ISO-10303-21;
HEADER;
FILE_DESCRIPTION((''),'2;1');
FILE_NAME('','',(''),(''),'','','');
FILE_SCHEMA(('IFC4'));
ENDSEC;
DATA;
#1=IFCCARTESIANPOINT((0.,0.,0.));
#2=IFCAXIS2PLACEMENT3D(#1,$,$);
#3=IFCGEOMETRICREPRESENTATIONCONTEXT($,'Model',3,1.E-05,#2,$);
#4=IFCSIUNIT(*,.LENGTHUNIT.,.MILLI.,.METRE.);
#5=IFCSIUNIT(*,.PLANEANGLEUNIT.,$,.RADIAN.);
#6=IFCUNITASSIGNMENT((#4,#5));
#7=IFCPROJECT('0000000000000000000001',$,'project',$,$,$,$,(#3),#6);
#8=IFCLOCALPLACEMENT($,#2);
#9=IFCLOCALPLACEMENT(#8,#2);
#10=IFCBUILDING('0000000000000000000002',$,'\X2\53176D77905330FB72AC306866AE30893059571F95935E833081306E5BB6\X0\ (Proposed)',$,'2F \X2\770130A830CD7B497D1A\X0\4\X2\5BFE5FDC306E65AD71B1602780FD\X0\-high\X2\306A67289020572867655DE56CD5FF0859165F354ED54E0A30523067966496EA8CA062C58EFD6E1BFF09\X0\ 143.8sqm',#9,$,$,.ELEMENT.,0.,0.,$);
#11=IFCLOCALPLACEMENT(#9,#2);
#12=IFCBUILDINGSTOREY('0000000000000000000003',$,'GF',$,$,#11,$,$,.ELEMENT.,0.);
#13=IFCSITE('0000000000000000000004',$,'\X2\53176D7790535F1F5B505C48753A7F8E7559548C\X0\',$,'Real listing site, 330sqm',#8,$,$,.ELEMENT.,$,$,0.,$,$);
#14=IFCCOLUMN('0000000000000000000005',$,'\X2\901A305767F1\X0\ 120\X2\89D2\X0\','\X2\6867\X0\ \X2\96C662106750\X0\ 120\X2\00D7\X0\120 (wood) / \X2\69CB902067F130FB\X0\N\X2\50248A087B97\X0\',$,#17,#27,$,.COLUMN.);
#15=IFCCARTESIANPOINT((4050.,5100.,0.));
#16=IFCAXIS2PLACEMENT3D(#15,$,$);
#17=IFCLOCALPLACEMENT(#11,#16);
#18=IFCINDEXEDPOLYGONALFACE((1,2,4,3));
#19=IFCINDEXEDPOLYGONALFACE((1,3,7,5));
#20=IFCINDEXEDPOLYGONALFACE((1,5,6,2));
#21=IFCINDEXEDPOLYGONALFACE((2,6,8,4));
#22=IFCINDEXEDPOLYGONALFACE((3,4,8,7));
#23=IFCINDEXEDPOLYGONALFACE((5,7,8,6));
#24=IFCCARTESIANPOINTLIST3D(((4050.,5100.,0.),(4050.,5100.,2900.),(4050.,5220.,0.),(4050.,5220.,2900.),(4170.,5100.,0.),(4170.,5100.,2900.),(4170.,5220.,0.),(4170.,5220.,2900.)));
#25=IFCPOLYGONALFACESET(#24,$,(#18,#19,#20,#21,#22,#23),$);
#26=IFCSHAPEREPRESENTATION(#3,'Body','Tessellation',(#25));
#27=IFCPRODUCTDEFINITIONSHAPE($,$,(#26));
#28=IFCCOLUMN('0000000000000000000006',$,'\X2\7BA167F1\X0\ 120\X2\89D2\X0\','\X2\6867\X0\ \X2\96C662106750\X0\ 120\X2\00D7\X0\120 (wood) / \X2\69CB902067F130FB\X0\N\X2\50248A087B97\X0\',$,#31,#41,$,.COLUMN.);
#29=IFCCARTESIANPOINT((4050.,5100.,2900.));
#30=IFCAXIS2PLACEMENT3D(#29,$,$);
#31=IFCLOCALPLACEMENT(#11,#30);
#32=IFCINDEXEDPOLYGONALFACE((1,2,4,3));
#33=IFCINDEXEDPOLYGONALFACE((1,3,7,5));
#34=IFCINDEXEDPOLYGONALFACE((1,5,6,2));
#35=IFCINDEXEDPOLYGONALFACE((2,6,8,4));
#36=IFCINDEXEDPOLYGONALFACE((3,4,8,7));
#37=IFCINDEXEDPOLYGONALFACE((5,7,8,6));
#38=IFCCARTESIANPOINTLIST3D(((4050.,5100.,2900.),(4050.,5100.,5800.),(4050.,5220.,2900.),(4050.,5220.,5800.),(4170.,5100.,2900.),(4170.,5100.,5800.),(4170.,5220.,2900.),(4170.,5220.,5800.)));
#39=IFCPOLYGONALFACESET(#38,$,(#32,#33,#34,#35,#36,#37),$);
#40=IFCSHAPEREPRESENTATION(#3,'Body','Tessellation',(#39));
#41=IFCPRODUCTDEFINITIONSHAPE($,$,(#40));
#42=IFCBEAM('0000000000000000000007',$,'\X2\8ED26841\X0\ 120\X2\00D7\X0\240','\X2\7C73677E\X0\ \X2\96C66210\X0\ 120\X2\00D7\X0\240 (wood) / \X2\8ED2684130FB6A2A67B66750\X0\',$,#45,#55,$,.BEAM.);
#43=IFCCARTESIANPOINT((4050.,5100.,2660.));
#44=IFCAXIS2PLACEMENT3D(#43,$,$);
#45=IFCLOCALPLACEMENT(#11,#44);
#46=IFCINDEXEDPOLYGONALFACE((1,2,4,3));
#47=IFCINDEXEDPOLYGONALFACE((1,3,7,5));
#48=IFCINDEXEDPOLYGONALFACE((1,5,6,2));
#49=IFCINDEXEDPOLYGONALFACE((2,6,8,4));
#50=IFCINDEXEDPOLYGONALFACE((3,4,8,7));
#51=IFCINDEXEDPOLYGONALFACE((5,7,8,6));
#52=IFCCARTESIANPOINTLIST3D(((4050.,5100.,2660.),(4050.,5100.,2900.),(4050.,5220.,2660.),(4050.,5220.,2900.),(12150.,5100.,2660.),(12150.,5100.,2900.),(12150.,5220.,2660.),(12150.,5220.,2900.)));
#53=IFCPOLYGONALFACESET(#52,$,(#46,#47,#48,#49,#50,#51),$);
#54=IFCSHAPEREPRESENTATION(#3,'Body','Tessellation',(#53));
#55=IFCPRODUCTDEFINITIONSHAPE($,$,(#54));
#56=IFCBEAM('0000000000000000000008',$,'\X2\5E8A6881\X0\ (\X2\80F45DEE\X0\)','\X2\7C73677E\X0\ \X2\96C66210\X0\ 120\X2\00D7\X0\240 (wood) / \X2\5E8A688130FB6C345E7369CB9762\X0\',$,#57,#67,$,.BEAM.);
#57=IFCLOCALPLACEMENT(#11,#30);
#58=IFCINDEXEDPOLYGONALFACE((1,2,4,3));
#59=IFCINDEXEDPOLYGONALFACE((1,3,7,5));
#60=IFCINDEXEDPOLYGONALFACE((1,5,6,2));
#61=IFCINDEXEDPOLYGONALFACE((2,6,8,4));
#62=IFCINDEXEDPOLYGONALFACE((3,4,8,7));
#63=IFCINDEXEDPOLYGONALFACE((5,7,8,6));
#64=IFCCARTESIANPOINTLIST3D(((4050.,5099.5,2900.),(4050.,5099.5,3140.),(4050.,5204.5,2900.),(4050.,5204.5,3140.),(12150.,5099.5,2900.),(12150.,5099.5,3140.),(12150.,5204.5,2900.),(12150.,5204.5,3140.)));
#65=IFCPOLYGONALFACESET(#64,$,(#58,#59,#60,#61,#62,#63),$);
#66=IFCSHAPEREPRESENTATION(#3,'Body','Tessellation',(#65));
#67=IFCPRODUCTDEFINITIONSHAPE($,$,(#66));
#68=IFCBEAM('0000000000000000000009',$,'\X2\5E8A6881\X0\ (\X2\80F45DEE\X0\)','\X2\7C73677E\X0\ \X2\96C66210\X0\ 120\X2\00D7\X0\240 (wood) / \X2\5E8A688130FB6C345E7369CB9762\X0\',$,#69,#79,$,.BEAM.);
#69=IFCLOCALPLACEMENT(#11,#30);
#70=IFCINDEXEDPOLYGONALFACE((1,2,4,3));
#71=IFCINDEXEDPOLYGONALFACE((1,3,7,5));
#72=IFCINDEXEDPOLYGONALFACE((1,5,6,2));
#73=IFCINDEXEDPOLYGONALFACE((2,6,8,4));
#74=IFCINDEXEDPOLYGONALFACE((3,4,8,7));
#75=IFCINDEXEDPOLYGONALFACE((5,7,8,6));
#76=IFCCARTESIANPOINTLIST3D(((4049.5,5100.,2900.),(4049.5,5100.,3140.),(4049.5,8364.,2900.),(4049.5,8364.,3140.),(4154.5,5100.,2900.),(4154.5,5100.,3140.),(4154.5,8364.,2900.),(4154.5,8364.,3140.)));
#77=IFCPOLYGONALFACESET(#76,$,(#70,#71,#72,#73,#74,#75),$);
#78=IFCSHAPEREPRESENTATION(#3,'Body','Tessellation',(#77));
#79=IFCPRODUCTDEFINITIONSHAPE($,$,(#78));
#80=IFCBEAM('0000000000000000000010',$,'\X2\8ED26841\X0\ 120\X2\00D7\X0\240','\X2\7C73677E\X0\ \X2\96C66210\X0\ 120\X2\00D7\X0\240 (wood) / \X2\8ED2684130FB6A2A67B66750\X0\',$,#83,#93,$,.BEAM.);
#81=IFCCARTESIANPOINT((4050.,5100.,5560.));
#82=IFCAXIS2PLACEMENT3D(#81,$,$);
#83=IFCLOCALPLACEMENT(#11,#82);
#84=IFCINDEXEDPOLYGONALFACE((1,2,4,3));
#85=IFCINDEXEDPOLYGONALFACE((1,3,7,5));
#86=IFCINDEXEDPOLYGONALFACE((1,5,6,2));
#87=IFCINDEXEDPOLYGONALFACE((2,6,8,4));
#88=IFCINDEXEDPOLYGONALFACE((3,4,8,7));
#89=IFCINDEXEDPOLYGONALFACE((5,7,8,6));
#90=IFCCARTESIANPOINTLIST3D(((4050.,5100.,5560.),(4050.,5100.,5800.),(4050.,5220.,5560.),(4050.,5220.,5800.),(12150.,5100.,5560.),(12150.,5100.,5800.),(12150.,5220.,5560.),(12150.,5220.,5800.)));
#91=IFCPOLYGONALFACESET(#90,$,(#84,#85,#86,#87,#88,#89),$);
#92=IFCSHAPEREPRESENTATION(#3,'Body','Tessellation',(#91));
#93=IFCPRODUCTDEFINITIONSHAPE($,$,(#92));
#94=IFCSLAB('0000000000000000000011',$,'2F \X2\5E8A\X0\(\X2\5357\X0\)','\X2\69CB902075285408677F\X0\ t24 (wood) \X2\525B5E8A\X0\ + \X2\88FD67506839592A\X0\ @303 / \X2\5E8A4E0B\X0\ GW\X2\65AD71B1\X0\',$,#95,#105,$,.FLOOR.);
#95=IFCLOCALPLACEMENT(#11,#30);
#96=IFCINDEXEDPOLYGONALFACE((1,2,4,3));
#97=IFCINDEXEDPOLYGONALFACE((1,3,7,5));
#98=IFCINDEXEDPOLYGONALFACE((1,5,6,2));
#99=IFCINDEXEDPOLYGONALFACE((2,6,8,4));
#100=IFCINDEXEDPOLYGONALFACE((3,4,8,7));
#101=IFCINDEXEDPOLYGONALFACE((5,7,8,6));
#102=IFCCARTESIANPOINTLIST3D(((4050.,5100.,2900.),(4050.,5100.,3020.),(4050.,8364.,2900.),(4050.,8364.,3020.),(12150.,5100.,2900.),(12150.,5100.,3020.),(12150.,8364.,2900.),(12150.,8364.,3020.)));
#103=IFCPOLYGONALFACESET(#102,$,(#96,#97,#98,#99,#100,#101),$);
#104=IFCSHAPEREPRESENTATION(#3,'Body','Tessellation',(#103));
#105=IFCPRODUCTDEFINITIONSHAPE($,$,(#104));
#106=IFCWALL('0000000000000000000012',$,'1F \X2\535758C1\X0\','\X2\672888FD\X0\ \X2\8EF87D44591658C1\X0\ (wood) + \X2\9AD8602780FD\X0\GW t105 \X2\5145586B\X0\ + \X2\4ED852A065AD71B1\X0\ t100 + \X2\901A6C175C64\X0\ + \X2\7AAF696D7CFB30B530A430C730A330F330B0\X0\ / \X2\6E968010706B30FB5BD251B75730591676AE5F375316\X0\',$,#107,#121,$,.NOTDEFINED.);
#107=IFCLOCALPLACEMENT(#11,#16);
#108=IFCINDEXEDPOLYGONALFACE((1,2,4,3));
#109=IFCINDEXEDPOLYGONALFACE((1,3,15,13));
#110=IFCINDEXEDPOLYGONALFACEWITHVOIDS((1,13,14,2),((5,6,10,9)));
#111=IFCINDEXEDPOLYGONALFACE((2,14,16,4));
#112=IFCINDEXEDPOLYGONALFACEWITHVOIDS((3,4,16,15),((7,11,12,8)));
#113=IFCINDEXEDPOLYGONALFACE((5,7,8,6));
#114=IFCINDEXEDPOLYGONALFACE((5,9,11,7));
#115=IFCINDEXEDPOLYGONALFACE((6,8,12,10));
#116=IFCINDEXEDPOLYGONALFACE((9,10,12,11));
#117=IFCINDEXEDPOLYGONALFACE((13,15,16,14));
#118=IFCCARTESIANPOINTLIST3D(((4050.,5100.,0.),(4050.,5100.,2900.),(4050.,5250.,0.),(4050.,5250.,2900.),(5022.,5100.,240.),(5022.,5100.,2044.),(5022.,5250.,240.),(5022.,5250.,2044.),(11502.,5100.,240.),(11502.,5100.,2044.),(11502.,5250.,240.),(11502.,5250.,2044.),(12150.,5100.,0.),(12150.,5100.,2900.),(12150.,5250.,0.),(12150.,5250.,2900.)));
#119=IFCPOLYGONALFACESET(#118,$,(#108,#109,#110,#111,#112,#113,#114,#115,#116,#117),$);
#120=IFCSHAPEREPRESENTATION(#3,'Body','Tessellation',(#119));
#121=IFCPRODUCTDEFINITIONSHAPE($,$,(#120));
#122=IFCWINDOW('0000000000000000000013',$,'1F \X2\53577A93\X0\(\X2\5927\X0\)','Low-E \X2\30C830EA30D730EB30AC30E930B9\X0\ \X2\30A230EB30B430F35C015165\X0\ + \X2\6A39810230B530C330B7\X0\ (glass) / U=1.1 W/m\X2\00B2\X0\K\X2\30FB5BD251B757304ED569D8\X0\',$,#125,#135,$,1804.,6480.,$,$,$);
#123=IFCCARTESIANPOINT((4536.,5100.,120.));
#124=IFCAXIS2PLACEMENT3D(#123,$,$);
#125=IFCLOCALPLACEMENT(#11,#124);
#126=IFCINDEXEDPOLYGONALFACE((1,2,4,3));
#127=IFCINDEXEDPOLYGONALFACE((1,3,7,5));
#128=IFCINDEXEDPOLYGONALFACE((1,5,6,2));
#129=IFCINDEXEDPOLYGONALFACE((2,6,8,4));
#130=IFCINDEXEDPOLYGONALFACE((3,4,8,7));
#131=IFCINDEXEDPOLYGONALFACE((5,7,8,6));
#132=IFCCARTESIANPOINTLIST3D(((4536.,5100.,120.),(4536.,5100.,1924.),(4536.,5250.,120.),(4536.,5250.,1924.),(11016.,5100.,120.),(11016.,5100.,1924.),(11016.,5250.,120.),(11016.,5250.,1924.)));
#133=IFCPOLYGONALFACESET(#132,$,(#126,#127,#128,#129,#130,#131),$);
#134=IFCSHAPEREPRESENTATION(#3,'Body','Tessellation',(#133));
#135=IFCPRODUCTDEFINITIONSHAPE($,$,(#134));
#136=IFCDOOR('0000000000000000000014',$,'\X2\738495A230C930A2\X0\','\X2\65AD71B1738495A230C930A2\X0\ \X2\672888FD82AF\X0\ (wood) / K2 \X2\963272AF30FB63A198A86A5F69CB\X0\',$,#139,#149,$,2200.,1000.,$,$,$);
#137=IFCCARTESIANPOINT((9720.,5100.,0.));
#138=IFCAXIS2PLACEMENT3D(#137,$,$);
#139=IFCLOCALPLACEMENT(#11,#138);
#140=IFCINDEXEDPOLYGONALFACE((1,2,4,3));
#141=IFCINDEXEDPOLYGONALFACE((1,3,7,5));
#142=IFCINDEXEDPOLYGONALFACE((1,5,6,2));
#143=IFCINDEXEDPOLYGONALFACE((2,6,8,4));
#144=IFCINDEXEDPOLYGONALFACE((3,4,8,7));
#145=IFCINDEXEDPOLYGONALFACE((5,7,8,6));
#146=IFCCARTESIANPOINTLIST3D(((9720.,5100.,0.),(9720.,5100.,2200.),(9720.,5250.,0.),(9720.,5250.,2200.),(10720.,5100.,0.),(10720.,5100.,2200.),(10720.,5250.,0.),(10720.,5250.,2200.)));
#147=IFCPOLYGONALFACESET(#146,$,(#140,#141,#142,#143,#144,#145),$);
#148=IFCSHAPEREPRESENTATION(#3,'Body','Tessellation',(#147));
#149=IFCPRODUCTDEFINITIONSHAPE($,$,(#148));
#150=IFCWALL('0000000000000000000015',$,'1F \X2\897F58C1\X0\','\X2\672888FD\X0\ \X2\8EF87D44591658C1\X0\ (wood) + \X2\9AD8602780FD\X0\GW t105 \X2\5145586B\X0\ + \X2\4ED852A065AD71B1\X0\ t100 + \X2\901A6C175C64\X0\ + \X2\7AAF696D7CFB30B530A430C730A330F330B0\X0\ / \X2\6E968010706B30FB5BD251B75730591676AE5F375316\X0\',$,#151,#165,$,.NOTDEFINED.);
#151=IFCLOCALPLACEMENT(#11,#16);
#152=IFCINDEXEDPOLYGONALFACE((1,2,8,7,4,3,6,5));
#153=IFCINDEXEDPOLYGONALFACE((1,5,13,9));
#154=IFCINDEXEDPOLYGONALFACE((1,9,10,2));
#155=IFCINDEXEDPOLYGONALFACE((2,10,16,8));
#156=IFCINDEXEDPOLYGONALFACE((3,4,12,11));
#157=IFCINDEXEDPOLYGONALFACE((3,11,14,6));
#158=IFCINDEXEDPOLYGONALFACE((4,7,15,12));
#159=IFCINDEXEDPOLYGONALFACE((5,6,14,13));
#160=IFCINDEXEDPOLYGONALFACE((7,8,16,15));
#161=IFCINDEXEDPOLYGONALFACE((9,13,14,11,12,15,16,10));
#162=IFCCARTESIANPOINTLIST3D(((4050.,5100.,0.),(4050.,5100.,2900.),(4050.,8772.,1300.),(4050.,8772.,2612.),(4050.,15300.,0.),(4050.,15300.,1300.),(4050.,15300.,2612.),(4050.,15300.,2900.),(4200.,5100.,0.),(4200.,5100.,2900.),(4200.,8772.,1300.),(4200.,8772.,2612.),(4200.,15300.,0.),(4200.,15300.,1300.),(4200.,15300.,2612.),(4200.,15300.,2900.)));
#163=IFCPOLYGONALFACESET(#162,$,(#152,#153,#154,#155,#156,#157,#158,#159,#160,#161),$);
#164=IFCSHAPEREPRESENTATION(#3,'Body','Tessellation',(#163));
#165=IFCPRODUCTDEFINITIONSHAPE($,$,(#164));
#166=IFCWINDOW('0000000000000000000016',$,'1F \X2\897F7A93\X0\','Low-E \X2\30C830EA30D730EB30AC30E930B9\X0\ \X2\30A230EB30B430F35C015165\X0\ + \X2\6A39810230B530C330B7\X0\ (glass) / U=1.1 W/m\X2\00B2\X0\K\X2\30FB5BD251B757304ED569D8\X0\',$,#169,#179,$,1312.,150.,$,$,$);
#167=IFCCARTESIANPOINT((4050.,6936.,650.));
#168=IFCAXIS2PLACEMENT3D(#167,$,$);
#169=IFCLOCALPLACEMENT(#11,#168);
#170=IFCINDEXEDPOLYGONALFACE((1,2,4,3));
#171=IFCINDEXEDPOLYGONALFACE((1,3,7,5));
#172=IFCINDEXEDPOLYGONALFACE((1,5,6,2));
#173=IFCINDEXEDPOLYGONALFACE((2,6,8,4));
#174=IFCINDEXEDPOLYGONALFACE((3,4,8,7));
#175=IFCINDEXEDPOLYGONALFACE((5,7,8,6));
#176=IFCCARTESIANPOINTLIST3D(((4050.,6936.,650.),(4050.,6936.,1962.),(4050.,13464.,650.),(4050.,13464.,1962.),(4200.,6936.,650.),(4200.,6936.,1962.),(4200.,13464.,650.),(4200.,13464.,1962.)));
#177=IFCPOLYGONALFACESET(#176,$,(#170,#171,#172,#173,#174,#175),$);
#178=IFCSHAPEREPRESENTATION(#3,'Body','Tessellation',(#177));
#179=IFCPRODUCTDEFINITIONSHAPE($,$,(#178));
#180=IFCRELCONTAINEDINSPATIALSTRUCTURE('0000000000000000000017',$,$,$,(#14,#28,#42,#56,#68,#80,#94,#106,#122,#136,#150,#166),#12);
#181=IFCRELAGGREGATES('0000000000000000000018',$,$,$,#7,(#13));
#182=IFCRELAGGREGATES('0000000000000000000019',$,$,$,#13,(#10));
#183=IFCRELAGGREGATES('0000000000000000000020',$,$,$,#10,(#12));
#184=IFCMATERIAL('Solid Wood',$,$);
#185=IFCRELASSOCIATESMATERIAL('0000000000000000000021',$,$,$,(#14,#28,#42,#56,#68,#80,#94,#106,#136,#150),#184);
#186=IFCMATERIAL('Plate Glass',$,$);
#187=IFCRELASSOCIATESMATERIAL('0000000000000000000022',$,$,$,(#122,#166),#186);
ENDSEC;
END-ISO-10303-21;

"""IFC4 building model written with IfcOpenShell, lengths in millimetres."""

from ifc_helpers import new_model, si_unit, frame, frame_2d, origin, place, context, project, spatial, rectangle, extrude, material, element, fill, save


model = new_model("IFC4")

# Units and contexts
model_context = context("Model", 3, precision=1e-05, world=origin())
ifc_project = project(units=[si_unit("LENGTHUNIT", "METRE", prefix="MILLI"), si_unit("PLANEANGLEUNIT", "RADIAN")], contexts=[model_context])

# Site, building, storey
site_placement = place(None, origin())
site = spatial("IfcSite", under=ifc_project, at=site_placement, Name="北海道弟子屈町美留和", ObjectType="Real listing site, 330sqm", CompositionType="ELEMENT", RefElevation=0.0)
building_placement = place(site_placement, origin())
building = spatial("IfcBuilding", under=site, at=building_placement, Name="北海道・犬と暮らす土間広めの家 (Proposed)", ObjectType="2F 省エネ等級4対応の断熱性能-highな木造在来工法（外張仕上げで除雪負担軽減） 143.8sqm", CompositionType="ELEMENT", ElevationOfRefHeight=0.0, ElevationOfTerrain=0.0)
storey_placement = place(building_placement, origin())
storey = spatial("IfcBuildingStorey", under=building, at=storey_placement, Name="GF", CompositionType="ELEMENT", Elevation=0.0)

# Columns
ifc_material_1 = material(Name="Solid Wood")
column_1_placement = place(storey_placement, frame((4050.0, 5100.0, 0.0)))
element("IfcColumn", 1, at=column_1_placement, inside=storey, material=ifc_material_1, Name="通し柱 120角", Description="桧 集成材 120×120 (wood) / 構造柱・N値計算", PredefinedType="COLUMN", context=model_context, shape_type="SweptSolid", body=[
    extrude(rectangle(XDim=120.0, YDim=120.0, at=frame_2d((60.0, 60.0))), frame((4050.0, 5100.0, 0.0)), (0.0, 0.0, 1.0), 2900.0),
])
column_2_placement = place(storey_placement, frame((4050.0, 5100.0, 2900.0)))
element("IfcColumn", 2, at=column_2_placement, inside=storey, material=ifc_material_1, Name="管柱 120角", Description="桧 集成材 120×120 (wood) / 構造柱・N値計算", PredefinedType="COLUMN", context=model_context, shape_type="SweptSolid", body=[
    extrude(rectangle(XDim=120.0, YDim=120.0, at=frame_2d((60.0, 60.0))), frame((4050.0, 5100.0, 2900.0)), (0.0, 0.0, 1.0), 2900.0),
])

# Beams
beam_1_placement = place(storey_placement, frame((4050.0, 5100.0, 2660.0)))
element("IfcBeam", 3, at=beam_1_placement, inside=storey, material=ifc_material_1, Name="軒桁 120×240", Description="米松 集成 120×240 (wood) / 軒桁・横架材", PredefinedType="BEAM", context=model_context, shape_type="SweptSolid", body=[
    extrude(rectangle(XDim=8100.0, YDim=120.0, at=frame_2d((4050.0, 60.0))), frame((4050.0, 5100.0, 2660.0)), (0.0, 0.0, 1.0), 240.0),
])
beam_2_placement = place(storey_placement, frame((4050.0, 5100.0, 2900.0)))
element("IfcBeam", 4, at=beam_2_placement, inside=storey, material=ifc_material_1, Name="床梁 (胴差)", Description="米松 集成 120×240 (wood) / 床梁・水平構面", PredefinedType="BEAM", context=model_context, shape_type="SweptSolid", body=[
    extrude(rectangle(XDim=8100.0, YDim=105.0, at=frame_2d((4050.0, 52.0))), frame((4050.0, 5100.0, 2900.0)), (0.0, 0.0, 1.0), 240.0),
])
beam_3_placement = place(storey_placement, frame((4050.0, 5100.0, 2900.0)))
element("IfcBeam", 5, at=beam_3_placement, inside=storey, material=ifc_material_1, Name="床梁 (胴差)", Description="米松 集成 120×240 (wood) / 床梁・水平構面", PredefinedType="BEAM", context=model_context, shape_type="SweptSolid", body=[
    extrude(rectangle(XDim=105.0, YDim=3264.0, at=frame_2d((52.0, 1632.0))), frame((4050.0, 5100.0, 2900.0)), (0.0, 0.0, 1.0), 240.0),
])
beam_4_placement = place(storey_placement, frame((4050.0, 5100.0, 5560.0)))
element("IfcBeam", 6, at=beam_4_placement, inside=storey, material=ifc_material_1, Name="軒桁 120×240", Description="米松 集成 120×240 (wood) / 軒桁・横架材", PredefinedType="BEAM", context=model_context, shape_type="SweptSolid", body=[
    extrude(rectangle(XDim=8100.0, YDim=120.0, at=frame_2d((4050.0, 60.0))), frame((4050.0, 5100.0, 5560.0)), (0.0, 0.0, 1.0), 240.0),
])

# Slab
slab_1_placement = place(storey_placement, frame((4050.0, 5100.0, 2900.0)))
element("IfcSlab", 7, at=slab_1_placement, inside=storey, material=ifc_material_1, Name="2F 床(南)", Description="構造用合板 t24 (wood) 剛床 + 製材根太 @303 / 床下 GW断熱", PredefinedType="FLOOR", context=model_context, shape_type="SweptSolid", body=[
    extrude(rectangle(XDim=8100.0, YDim=3264.0, at=frame_2d((4050.0, 1632.0))), frame((4050.0, 5100.0, 2900.0)), (0.0, 0.0, 1.0), 120.0),
])

# Wall, openings, window, door
wall_1_placement = place(storey_placement, frame((4050.0, 5100.0, 0.0)))
wall_1 = element("IfcWall", 8, at=wall_1_placement, inside=storey, material=ifc_material_1, Name="1F 南壁", Description="木製 軸組外壁 (wood) + 高性能GW t105 充填 + 付加断熱 t100 + 通気層 + 窯業系サイディング / 準耐火・寒冷地外皮強化", PredefinedType="NOTDEFINED", context=model_context, shape_type="SweptSolid", body=[
    extrude(rectangle(XDim=8100.0, YDim=150.0, at=frame_2d((4050.0, 75.0))), frame((4050.0, 5100.0, 0.0)), (0.0, 0.0, 1.0), 2900.0),
])
opening_1_placement = place(storey_placement, frame((4536.0, 5100.0, 120.0)))
opening_1 = element("IfcOpeningElement", 9, at=opening_1_placement, cuts=wall_1, PredefinedType="NOTDEFINED", context=model_context, shape_type="SweptSolid", body=[
    extrude(rectangle(XDim=6480.0, YDim=150.0, at=frame_2d((3240.0, 75.0))), frame((4536.0, 5100.0, 120.0)), (0.0, 0.0, 1.0), 1804.0),
])
opening_2_placement = place(storey_placement, frame((9720.0, 5100.0, 0.0)))
opening_2 = element("IfcOpeningElement", 10, at=opening_2_placement, cuts=wall_1, PredefinedType="NOTDEFINED", context=model_context, shape_type="SweptSolid", body=[
    extrude(rectangle(XDim=1000.0, YDim=150.0, at=frame_2d((500.0, 75.0))), frame((9720.0, 5100.0, 0.0)), (0.0, 0.0, 1.0), 2200.0),
])
ifc_material_2 = material(Name="Plate Glass")
window_1_placement = place(storey_placement, frame((4536.0, 5100.0, 120.0)))
window_1 = element("IfcWindow", 11, at=window_1_placement, inside=storey, material=ifc_material_2, Name="1F 南窓(大)", Description="Low-E トリプルガラス アルゴン封入 + 樹脂サッシ (glass) / U=1.1 W/m²K・寒冷地仕様", OverallHeight=1804.0, OverallWidth=6480.0, context=model_context, shape_type="SweptSolid", body=[
    extrude(rectangle(XDim=6480.0, YDim=150.0, at=frame_2d((3240.0, 75.0))), frame((4536.0, 5100.0, 120.0)), (0.0, 0.0, 1.0), 1804.0),
])
fill(opening_1, window_1)
door_placement = place(storey_placement, frame((9720.0, 5100.0, 0.0)))
door = element("IfcDoor", 12, at=door_placement, inside=storey, material=ifc_material_1, Name="玄関ドア", Description="断熱玄関ドア 木製芯 (wood) / K2 防犯・採風機構", OverallHeight=2200.0, OverallWidth=1000.0, context=model_context, shape_type="SweptSolid", body=[
    extrude(rectangle(XDim=1000.0, YDim=150.0, at=frame_2d((500.0, 75.0))), frame((9720.0, 5100.0, 0.0)), (0.0, 0.0, 1.0), 2200.0),
])
fill(opening_2, door)

# Wall, opening, window
wall_2_placement = place(storey_placement, frame((4050.0, 5100.0, 0.0)))
wall_2 = element("IfcWall", 13, at=wall_2_placement, inside=storey, material=ifc_material_1, Name="1F 西壁", Description="木製 軸組外壁 (wood) + 高性能GW t105 充填 + 付加断熱 t100 + 通気層 + 窯業系サイディング / 準耐火・寒冷地外皮強化", PredefinedType="NOTDEFINED", context=model_context, shape_type="SweptSolid", body=[
    extrude(rectangle(XDim=150.0, YDim=10200.0, at=frame_2d((75.0, 5100.0))), frame((4050.0, 5100.0, 0.0)), (0.0, 0.0, 1.0), 2900.0),
])
opening_3_placement = place(storey_placement, frame((4050.0, 6936.0, 650.0)))
opening_3 = element("IfcOpeningElement", 14, at=opening_3_placement, cuts=wall_2, PredefinedType="NOTDEFINED", context=model_context, shape_type="SweptSolid", body=[
    extrude(rectangle(XDim=150.0, YDim=6528.0, at=frame_2d((75.0, 3264.0))), frame((4050.0, 6936.0, 650.0)), (0.0, 0.0, 1.0), 1312.0),
])
window_2_placement = place(storey_placement, frame((4050.0, 6936.0, 650.0)))
window_2 = element("IfcWindow", 15, at=window_2_placement, inside=storey, material=ifc_material_2, Name="1F 西窓", Description="Low-E トリプルガラス アルゴン封入 + 樹脂サッシ (glass) / U=1.1 W/m²K・寒冷地仕様", OverallHeight=1312.0, OverallWidth=150.0, context=model_context, shape_type="SweptSolid", body=[
    extrude(rectangle(XDim=150.0, YDim=6528.0, at=frame_2d((75.0, 3264.0))), frame((4050.0, 6936.0, 650.0)), (0.0, 0.0, 1.0), 1312.0),
])
fill(opening_3, window_2)

save(model, "model.ifc")
